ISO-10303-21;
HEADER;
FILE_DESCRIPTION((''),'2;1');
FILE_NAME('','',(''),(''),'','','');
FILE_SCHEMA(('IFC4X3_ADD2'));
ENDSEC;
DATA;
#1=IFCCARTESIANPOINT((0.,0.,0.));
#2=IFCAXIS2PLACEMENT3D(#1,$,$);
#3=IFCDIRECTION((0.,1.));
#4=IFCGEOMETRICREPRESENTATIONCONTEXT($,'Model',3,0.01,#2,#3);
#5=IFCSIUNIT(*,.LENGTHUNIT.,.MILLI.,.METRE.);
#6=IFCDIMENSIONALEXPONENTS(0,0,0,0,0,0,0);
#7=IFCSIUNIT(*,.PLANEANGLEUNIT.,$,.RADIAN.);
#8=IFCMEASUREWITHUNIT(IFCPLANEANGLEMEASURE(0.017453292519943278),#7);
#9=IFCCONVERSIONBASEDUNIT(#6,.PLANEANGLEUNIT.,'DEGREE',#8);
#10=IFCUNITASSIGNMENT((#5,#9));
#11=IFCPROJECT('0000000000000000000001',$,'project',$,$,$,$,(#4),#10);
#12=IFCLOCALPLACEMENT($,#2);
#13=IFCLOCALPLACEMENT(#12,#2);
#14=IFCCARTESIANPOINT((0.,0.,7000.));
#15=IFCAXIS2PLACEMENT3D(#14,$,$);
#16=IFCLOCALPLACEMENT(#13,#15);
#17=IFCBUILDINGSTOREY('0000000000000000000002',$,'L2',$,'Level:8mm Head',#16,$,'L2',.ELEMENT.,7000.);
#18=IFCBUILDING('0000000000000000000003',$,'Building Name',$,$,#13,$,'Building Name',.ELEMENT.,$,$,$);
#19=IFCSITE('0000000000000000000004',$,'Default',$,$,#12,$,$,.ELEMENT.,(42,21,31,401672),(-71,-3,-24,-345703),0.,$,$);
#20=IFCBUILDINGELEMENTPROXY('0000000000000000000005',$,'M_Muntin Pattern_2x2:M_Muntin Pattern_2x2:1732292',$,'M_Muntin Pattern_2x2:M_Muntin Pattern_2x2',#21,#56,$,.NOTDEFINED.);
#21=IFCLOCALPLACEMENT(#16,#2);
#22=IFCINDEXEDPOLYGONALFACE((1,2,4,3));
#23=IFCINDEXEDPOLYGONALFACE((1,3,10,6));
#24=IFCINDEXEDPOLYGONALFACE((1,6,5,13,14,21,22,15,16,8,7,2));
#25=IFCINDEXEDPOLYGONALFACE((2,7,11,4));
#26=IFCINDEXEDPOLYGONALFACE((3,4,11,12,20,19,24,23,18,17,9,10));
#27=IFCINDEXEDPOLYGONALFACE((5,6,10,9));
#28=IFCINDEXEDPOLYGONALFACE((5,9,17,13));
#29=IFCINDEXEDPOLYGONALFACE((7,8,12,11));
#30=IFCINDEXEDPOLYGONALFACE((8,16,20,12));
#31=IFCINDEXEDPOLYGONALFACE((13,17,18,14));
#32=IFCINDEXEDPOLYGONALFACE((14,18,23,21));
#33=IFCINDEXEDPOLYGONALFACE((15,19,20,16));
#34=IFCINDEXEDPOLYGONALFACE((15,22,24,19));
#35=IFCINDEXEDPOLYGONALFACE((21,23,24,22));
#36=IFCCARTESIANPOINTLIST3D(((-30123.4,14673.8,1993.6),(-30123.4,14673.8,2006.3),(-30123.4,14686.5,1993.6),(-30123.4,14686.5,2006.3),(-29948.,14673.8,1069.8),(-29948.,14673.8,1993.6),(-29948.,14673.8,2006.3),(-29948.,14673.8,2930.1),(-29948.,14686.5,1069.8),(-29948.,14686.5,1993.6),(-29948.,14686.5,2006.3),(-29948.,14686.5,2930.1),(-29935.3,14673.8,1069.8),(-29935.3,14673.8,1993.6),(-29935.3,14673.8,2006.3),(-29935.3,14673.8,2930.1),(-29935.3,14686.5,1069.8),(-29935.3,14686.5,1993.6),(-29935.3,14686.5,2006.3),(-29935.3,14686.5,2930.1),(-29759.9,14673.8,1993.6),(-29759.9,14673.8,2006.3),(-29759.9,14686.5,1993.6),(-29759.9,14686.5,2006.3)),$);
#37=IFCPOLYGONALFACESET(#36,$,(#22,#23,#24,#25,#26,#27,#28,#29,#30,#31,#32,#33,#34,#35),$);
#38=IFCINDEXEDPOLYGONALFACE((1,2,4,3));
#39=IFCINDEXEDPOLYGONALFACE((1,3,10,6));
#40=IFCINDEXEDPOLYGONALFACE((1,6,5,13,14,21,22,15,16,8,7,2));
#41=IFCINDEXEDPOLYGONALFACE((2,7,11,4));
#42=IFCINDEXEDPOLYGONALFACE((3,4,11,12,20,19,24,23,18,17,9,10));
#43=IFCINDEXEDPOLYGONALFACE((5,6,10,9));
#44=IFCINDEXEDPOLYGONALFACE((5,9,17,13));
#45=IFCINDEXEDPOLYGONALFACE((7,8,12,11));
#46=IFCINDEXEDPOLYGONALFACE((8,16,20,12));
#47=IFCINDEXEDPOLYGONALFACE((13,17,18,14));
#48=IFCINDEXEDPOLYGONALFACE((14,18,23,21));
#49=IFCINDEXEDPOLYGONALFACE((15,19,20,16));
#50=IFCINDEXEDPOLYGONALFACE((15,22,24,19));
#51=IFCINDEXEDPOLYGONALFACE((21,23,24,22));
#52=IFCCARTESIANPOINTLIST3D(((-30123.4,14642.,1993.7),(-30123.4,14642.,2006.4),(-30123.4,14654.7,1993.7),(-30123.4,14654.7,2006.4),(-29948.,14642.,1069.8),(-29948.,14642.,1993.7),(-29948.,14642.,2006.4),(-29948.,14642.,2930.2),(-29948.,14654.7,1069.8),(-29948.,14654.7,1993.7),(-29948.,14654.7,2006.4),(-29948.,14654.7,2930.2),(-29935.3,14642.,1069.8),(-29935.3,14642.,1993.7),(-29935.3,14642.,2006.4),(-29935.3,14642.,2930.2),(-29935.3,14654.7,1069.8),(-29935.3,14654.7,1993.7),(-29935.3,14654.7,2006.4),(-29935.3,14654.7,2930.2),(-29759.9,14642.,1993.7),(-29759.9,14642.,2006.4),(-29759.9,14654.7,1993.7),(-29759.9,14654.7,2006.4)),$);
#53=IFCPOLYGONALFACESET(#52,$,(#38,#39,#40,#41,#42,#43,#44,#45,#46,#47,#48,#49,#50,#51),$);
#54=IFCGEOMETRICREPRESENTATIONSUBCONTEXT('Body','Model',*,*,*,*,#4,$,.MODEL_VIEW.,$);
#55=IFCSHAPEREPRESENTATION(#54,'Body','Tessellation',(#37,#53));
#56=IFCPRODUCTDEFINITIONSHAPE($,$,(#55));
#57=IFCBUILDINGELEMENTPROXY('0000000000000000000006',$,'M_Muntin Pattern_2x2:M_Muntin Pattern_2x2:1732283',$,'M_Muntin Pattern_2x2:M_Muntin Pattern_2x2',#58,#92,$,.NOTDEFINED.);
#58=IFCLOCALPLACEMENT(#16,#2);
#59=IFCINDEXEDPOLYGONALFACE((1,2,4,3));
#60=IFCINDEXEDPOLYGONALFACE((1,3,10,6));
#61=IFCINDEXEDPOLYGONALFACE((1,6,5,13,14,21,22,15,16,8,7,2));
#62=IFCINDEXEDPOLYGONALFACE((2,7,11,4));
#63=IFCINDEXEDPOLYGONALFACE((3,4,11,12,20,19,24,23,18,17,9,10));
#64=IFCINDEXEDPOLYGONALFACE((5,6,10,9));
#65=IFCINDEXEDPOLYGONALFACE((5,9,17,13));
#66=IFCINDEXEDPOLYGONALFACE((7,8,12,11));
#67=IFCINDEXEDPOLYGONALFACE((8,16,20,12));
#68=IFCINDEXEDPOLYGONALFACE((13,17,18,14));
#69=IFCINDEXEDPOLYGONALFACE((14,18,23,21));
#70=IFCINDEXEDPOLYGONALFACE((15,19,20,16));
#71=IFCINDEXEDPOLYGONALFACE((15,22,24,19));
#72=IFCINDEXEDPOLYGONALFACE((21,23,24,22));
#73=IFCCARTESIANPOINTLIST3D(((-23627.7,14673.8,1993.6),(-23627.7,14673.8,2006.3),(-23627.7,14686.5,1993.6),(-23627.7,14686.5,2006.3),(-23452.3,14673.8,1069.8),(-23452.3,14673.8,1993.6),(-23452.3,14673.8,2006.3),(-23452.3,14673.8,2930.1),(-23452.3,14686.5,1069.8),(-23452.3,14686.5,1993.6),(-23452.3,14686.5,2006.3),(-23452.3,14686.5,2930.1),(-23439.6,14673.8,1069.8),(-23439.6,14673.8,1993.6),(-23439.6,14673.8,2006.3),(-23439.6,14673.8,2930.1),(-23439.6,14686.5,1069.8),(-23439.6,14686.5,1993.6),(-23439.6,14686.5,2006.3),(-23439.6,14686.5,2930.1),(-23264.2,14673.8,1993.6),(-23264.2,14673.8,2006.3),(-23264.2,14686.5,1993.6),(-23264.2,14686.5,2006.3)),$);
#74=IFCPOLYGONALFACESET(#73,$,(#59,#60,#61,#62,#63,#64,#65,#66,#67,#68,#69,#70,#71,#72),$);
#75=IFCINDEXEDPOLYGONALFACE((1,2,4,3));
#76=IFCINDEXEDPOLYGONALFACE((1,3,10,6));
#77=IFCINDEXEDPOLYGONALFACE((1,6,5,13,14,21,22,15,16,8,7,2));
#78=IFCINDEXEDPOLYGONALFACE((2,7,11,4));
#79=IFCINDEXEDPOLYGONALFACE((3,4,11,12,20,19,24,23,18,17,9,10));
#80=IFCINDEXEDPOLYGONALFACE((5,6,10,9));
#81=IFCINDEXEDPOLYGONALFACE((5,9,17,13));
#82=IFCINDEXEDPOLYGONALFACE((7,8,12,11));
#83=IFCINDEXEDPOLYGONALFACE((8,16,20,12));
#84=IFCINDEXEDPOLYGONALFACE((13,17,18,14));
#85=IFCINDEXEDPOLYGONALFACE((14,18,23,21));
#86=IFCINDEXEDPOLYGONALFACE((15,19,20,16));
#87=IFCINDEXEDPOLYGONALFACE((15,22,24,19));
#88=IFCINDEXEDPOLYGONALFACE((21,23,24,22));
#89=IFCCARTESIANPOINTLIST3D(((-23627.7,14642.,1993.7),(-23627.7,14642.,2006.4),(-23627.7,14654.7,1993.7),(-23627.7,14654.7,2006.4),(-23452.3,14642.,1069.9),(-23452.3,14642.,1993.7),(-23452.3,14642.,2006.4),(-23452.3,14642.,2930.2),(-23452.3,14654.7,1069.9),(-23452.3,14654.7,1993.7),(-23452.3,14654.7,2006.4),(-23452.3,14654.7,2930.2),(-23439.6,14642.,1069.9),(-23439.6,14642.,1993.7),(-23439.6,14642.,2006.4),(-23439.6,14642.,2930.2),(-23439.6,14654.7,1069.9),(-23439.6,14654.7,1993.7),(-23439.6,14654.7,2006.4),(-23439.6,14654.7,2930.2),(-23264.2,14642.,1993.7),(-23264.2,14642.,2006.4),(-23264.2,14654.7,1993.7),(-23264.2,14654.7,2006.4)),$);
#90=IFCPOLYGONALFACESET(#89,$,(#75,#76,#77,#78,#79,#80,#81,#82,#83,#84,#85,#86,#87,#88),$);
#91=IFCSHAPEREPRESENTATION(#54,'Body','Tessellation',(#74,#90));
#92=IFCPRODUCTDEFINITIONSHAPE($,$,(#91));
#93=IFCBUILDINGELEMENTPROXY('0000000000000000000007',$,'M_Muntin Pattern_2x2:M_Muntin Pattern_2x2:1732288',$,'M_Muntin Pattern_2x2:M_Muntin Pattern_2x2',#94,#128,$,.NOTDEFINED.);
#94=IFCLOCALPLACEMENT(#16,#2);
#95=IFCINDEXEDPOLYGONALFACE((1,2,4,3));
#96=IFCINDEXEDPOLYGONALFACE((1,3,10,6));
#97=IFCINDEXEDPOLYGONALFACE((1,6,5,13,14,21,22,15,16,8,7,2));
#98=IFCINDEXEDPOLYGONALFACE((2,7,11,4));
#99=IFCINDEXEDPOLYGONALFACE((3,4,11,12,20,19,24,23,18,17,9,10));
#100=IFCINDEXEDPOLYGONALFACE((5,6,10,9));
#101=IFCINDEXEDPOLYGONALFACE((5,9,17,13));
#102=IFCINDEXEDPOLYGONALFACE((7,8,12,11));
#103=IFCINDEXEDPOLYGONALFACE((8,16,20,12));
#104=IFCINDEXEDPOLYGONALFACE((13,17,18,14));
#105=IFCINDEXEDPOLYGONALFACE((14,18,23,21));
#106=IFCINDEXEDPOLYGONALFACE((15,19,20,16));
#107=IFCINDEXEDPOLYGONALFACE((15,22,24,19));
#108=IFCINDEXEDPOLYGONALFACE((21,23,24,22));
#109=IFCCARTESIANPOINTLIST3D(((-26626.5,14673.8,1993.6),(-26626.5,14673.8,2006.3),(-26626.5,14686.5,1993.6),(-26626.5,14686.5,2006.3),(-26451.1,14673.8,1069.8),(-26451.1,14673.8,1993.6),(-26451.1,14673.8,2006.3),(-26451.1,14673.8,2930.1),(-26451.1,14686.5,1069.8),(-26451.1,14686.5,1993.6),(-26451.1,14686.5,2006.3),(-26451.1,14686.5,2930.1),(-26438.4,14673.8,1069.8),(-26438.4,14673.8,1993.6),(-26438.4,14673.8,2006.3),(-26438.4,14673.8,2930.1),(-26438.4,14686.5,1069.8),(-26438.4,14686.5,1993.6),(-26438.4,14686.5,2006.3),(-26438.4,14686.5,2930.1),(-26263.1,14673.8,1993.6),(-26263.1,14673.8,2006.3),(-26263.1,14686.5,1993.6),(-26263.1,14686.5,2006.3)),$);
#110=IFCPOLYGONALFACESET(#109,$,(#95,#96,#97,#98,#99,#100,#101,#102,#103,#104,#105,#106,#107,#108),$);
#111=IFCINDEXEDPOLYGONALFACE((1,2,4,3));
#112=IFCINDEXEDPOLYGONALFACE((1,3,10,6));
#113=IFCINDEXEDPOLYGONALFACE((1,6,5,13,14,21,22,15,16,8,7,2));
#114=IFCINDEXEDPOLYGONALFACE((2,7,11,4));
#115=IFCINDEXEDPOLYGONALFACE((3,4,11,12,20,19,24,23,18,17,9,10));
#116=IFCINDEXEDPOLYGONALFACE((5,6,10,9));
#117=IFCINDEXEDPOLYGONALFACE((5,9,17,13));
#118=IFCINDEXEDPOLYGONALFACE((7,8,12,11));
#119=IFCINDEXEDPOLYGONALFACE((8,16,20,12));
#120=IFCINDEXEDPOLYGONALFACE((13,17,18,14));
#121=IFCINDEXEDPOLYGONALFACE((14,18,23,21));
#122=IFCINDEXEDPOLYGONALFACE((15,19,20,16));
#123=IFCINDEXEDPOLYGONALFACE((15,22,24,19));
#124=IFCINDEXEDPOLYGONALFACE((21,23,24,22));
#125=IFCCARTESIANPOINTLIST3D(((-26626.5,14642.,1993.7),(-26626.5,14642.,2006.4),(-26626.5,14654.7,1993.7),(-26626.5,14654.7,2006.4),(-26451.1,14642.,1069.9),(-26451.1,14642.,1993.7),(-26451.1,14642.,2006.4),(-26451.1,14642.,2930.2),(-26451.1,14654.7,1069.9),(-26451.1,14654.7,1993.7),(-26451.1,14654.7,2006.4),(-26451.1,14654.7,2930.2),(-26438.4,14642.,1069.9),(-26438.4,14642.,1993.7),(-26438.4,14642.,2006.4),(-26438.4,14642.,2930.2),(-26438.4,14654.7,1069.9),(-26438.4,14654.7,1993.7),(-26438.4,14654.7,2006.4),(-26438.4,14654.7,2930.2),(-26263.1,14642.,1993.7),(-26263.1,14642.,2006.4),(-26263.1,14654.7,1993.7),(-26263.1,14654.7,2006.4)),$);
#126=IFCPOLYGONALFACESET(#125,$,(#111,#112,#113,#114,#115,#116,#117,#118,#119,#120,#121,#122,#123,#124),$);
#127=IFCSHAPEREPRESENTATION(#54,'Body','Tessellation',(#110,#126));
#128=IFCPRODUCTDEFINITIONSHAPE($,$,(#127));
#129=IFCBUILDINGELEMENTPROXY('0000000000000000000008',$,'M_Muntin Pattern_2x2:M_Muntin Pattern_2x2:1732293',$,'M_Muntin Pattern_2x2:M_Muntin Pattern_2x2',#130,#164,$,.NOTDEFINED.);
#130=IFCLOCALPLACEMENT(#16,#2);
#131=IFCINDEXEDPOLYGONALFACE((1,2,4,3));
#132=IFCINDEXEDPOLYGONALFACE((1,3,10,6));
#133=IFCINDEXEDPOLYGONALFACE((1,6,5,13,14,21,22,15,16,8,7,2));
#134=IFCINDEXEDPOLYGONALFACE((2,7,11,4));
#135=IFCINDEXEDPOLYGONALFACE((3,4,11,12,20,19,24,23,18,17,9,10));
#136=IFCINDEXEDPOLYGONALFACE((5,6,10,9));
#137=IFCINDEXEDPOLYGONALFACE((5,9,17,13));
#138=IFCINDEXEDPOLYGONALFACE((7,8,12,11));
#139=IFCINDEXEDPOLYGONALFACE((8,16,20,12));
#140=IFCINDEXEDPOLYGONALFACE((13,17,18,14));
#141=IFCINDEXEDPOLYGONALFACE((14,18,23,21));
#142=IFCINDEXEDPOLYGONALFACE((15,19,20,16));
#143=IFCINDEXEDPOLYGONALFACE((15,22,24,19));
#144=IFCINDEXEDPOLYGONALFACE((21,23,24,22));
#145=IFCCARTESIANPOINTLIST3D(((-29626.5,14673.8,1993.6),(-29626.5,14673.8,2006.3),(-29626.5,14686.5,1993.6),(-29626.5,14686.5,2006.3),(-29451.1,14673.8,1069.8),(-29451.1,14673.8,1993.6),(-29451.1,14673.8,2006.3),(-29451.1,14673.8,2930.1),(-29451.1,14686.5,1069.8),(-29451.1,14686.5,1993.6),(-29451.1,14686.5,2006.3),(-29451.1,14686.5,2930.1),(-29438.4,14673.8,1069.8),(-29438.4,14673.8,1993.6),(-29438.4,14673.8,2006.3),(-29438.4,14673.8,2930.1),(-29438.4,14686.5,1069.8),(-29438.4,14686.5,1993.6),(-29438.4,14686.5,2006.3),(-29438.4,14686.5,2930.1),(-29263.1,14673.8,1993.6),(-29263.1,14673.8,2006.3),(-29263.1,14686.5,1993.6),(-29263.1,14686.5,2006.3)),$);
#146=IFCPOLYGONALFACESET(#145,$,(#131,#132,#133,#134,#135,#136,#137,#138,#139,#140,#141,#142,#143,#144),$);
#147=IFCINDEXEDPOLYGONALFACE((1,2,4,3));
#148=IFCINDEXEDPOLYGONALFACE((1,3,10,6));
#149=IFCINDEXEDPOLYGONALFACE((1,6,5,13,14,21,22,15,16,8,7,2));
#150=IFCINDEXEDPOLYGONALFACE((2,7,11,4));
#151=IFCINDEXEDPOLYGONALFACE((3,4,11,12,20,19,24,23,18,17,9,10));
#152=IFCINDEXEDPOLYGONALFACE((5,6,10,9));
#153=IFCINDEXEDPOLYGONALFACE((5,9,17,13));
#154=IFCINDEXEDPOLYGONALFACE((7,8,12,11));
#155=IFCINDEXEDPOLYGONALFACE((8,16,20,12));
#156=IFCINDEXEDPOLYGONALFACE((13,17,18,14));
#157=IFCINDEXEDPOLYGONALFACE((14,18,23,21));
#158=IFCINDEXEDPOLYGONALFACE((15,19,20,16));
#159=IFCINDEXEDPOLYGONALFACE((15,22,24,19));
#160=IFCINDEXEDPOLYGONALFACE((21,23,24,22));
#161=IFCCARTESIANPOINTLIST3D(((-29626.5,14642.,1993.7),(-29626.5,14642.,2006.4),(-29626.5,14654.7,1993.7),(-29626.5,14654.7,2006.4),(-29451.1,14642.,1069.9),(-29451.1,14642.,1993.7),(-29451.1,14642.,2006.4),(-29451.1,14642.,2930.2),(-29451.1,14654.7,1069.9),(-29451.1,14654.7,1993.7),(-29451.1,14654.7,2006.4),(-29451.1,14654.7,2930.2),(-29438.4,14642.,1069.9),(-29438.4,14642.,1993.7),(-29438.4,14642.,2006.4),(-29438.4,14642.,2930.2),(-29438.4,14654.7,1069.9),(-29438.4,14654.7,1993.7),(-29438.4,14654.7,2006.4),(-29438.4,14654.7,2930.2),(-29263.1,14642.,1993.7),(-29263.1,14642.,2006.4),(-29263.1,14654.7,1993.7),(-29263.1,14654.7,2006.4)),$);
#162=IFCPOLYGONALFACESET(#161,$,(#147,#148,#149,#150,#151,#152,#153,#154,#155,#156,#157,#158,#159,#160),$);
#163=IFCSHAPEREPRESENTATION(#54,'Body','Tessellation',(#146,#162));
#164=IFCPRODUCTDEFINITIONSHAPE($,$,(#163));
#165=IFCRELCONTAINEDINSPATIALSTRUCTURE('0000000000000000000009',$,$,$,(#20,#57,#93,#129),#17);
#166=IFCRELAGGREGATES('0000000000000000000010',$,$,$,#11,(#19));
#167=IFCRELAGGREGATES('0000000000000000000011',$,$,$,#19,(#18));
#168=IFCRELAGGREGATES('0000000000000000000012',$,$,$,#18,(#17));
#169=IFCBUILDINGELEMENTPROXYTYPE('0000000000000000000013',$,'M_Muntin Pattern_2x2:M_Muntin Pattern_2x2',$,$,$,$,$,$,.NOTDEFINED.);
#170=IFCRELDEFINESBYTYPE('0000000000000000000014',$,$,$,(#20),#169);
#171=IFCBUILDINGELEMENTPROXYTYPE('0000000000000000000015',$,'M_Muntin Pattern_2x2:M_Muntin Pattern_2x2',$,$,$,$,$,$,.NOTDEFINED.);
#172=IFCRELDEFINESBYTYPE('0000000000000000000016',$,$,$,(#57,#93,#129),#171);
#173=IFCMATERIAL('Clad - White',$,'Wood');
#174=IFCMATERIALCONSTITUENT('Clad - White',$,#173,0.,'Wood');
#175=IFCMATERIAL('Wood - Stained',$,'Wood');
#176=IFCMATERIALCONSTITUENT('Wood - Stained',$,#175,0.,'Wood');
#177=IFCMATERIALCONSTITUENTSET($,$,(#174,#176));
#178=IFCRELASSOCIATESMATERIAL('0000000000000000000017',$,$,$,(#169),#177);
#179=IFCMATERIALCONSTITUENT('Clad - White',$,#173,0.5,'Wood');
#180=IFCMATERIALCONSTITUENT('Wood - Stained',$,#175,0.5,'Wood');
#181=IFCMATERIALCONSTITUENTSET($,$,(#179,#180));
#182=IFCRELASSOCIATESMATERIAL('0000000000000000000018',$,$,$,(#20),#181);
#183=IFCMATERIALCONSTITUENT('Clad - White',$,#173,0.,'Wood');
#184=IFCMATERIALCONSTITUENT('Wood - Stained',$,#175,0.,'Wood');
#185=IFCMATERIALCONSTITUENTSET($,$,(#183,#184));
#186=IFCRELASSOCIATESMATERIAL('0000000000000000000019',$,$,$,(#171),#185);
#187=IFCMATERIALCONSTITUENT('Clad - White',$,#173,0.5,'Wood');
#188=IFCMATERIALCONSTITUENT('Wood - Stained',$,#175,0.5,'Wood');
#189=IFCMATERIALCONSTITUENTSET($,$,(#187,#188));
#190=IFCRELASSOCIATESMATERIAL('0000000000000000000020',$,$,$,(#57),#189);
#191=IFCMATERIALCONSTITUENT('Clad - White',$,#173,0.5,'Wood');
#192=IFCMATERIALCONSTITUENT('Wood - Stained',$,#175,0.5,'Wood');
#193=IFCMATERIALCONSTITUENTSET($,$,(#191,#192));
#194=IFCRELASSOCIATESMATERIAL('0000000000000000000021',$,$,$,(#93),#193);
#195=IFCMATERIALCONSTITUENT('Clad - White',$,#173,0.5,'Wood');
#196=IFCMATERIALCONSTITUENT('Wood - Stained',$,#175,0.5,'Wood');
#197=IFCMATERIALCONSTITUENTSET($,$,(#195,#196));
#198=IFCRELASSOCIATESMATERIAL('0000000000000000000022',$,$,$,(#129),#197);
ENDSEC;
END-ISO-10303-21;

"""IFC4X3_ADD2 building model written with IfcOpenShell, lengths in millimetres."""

from ifc_helpers import new_model, entity, si_unit, converted_unit, direction, frame, origin, place, context, subcontext, project, spatial, polyline, outline, extrude, source, transform, mapped, material, constituent, constituent_set, type_object, type_shapes, element, save


model = new_model("IFC4X3_ADD2")

# Units and contexts
model_context = context("Model", 3, precision=0.01, world=origin(), true_north=direction((0.0, 1.0)))
body_context = subcontext(model_context, "Body", "Model", "MODEL_VIEW")
ifc_project = project(units=[si_unit("LENGTHUNIT", "METRE", prefix="MILLI"), converted_unit("PLANEANGLEUNIT", "DEGREE", entity("IfcPlaneAngleMeasure", 0.017453292519943278), si_unit("PLANEANGLEUNIT", "RADIAN"), dimensions=[0, 0, 0, 0, 0, 0, 0])], contexts=[model_context])

# Site, building, storey
site_placement = place(None, origin())
site = spatial("IfcSite", under=ifc_project, at=site_placement, Name="Default", CompositionType="ELEMENT", RefLatitude=(42, 21, 31, 401672), RefLongitude=(-71, -3, -24, -345703), RefElevation=0.0)
building_placement = place(site_placement, origin())
building = spatial("IfcBuilding", under=site, at=building_placement, Name="Building Name", LongName="Building Name", CompositionType="ELEMENT")
storey_placement = place(building_placement, frame((0.0, 0.0, 7000.0)))
storey = spatial("IfcBuildingStorey", under=building, at=storey_placement, Name="L2", ObjectType="Level:8mm Head", LongName="L2", CompositionType="ELEMENT", Elevation=7000.0)

# Building element proxies
ifc_material_1 = material(Name="Clad - White", Category="Wood")
ifc_material_2 = material(Name="Wood - Stained", Category="Wood")
ifc_constituent_1 = constituent(ifc_material_1, Name="Clad - White", Category="Wood", fraction=0.0)
ifc_constituent_2 = constituent(ifc_material_2, Name="Wood - Stained", Category="Wood", fraction=0.0)
ifc_constituent_set_1 = constituent_set(constituents=[ifc_constituent_1, ifc_constituent_2])
building_element_proxy_type_1 = type_object("IfcBuildingElementProxyType", Name="M_Muntin Pattern_2x2:M_Muntin Pattern_2x2", PredefinedType="NOTDEFINED", material=ifc_constituent_set_1)
shared_shape_1 = source(origin(), body_context, "Body", "SweptSolid", [
    extrude(outline(polyline([(6.4, -6.4), (930.1, -6.4), (930.1, 6.3), (6.4, 6.3), (6.4, 181.7), (-6.3, 181.7), (-6.3, 6.3), (-930.2, 6.3), (-930.2, -6.4), (-6.3, -6.4), (-6.3, -181.7), (6.4, -181.7), (6.4, -6.4)])), frame((0.0, 9.5, 930.1), z_axis=(0.0, 1.0, 0.0), x_axis=(0.0, 0.0, 1.0)), (0.0, 0.0, 1.0), 12.7),
    extrude(outline(polyline([(6.4, -6.4), (930.2, -6.4), (930.2, 6.3), (6.4, 6.3), (6.4, 181.7), (-6.3, 181.7), (-6.3, 6.3), (-930.2, 6.3), (-930.2, -6.4), (-6.3, -6.4), (-6.3, -181.7), (6.4, -181.7), (6.4, -6.4)])), frame((0.0, -22.2, 930.2), z_axis=(0.0, 1.0, 0.0), x_axis=(0.0, 0.0, 1.0)), (0.0, 0.0, 1.0), 12.7),
])
type_shapes(building_element_proxy_type_1, [shared_shape_1])
ifc_constituent_3 = constituent(ifc_material_1, Name="Clad - White", Category="Wood", fraction=0.5)
ifc_constituent_4 = constituent(ifc_material_2, Name="Wood - Stained", Category="Wood", fraction=0.5)
ifc_constituent_set_2 = constituent_set(constituents=[ifc_constituent_3, ifc_constituent_4])
proxy_1_placement = place(storey_placement, frame((-29941.6, 14664.3, 1069.8)))
element("IfcBuildingElementProxy", 1, at=proxy_1_placement, inside=storey, type_object=building_element_proxy_type_1, material=ifc_constituent_set_2, Name="M_Muntin Pattern_2x2:M_Muntin Pattern_2x2:1732292", ObjectType="M_Muntin Pattern_2x2:M_Muntin Pattern_2x2", PredefinedType="NOTDEFINED", context=body_context, shape_type="MappedRepresentation", body=[
    mapped(shared_shape_1, transform((0.0, 0.0, 0.0), scale=1.0)),
])
ifc_constituent_5 = constituent(ifc_material_1, Name="Clad - White", Category="Wood", fraction=0.5)
ifc_constituent_6 = constituent(ifc_material_2, Name="Wood - Stained", Category="Wood", fraction=0.5)
ifc_constituent_set_3 = constituent_set(constituents=[ifc_constituent_5, ifc_constituent_6])
ifc_constituent_7 = constituent(ifc_material_1, Name="Clad - White", Category="Wood", fraction=0.0)
ifc_constituent_8 = constituent(ifc_material_2, Name="Wood - Stained", Category="Wood", fraction=0.0)
ifc_constituent_set_4 = constituent_set(constituents=[ifc_constituent_7, ifc_constituent_8])
building_element_proxy_type_2 = type_object("IfcBuildingElementProxyType", Name="M_Muntin Pattern_2x2:M_Muntin Pattern_2x2", PredefinedType="NOTDEFINED", material=ifc_constituent_set_4)
shared_shape_2 = source(origin(), body_context, "Body", "SweptSolid", [
    extrude(outline(polyline([(6.4, -6.4), (930.1, -6.4), (930.1, 6.3), (6.4, 6.3), (6.4, 181.7), (-6.3, 181.7), (-6.3, 6.3), (-930.2, 6.3), (-930.2, -6.4), (-6.3, -6.4), (-6.3, -181.7), (6.4, -181.7), (6.4, -6.4)])), frame((0.0, -22.2, 930.1), z_axis=(0.0, 1.0, 0.0), x_axis=(0.0, 0.0, 1.0)), (0.0, 0.0, 1.0), 12.7),
    extrude(outline(polyline([(6.4, -6.4), (930.2, -6.4), (930.2, 6.3), (6.4, 6.3), (6.4, 181.7), (-6.3, 181.7), (-6.3, 6.3), (-930.2, 6.3), (-930.2, -6.4), (-6.3, -6.4), (-6.3, -181.7), (6.4, -181.7), (6.4, -6.4)])), frame((0.0, 9.5, 930.2), z_axis=(0.0, 1.0, 0.0), x_axis=(0.0, 0.0, 1.0)), (0.0, 0.0, 1.0), 12.7),
])
type_shapes(building_element_proxy_type_2, [shared_shape_2])
proxy_2_placement = place(storey_placement, frame((-23445.9, 14664.3, 1069.9), z_axis=(0.0, 0.0, 1.0), x_axis=(-1.0, 0.0, 0.0)))
element("IfcBuildingElementProxy", 2, at=proxy_2_placement, inside=storey, type_object=building_element_proxy_type_2, material=ifc_constituent_set_3, Name="M_Muntin Pattern_2x2:M_Muntin Pattern_2x2:1732283", ObjectType="M_Muntin Pattern_2x2:M_Muntin Pattern_2x2", PredefinedType="NOTDEFINED", context=body_context, shape_type="MappedRepresentation", body=[
    mapped(shared_shape_2, transform((0.0, 0.0, 0.0), scale=1.0)),
])
ifc_constituent_9 = constituent(ifc_material_1, Name="Clad - White", Category="Wood", fraction=0.5)
ifc_constituent_10 = constituent(ifc_material_2, Name="Wood - Stained", Category="Wood", fraction=0.5)
ifc_constituent_set_5 = constituent_set(constituents=[ifc_constituent_9, ifc_constituent_10])
proxy_3_placement = place(storey_placement, frame((-26444.8, 14664.3, 1069.9), z_axis=(0.0, 0.0, 1.0), x_axis=(-1.0, 0.0, 0.0)))
element("IfcBuildingElementProxy", 3, at=proxy_3_placement, inside=storey, type_object=building_element_proxy_type_2, material=ifc_constituent_set_5, Name="M_Muntin Pattern_2x2:M_Muntin Pattern_2x2:1732288", ObjectType="M_Muntin Pattern_2x2:M_Muntin Pattern_2x2", PredefinedType="NOTDEFINED", context=body_context, shape_type="MappedRepresentation", body=[
    mapped(shared_shape_2, transform((0.0, 0.0, 0.0), scale=1.0)),
])
ifc_constituent_11 = constituent(ifc_material_1, Name="Clad - White", Category="Wood", fraction=0.5)
ifc_constituent_12 = constituent(ifc_material_2, Name="Wood - Stained", Category="Wood", fraction=0.5)
ifc_constituent_set_6 = constituent_set(constituents=[ifc_constituent_11, ifc_constituent_12])
proxy_4_placement = place(storey_placement, frame((-29444.8, 14664.3, 1069.9), z_axis=(0.0, 0.0, 1.0), x_axis=(-1.0, 0.0, 0.0)))
element("IfcBuildingElementProxy", 4, at=proxy_4_placement, inside=storey, type_object=building_element_proxy_type_2, material=ifc_constituent_set_6, Name="M_Muntin Pattern_2x2:M_Muntin Pattern_2x2:1732293", ObjectType="M_Muntin Pattern_2x2:M_Muntin Pattern_2x2", PredefinedType="NOTDEFINED", context=body_context, shape_type="MappedRepresentation", body=[
    mapped(shared_shape_2, transform((0.0, 0.0, 0.0), scale=1.0)),
])

save(model, "model.ifc")
